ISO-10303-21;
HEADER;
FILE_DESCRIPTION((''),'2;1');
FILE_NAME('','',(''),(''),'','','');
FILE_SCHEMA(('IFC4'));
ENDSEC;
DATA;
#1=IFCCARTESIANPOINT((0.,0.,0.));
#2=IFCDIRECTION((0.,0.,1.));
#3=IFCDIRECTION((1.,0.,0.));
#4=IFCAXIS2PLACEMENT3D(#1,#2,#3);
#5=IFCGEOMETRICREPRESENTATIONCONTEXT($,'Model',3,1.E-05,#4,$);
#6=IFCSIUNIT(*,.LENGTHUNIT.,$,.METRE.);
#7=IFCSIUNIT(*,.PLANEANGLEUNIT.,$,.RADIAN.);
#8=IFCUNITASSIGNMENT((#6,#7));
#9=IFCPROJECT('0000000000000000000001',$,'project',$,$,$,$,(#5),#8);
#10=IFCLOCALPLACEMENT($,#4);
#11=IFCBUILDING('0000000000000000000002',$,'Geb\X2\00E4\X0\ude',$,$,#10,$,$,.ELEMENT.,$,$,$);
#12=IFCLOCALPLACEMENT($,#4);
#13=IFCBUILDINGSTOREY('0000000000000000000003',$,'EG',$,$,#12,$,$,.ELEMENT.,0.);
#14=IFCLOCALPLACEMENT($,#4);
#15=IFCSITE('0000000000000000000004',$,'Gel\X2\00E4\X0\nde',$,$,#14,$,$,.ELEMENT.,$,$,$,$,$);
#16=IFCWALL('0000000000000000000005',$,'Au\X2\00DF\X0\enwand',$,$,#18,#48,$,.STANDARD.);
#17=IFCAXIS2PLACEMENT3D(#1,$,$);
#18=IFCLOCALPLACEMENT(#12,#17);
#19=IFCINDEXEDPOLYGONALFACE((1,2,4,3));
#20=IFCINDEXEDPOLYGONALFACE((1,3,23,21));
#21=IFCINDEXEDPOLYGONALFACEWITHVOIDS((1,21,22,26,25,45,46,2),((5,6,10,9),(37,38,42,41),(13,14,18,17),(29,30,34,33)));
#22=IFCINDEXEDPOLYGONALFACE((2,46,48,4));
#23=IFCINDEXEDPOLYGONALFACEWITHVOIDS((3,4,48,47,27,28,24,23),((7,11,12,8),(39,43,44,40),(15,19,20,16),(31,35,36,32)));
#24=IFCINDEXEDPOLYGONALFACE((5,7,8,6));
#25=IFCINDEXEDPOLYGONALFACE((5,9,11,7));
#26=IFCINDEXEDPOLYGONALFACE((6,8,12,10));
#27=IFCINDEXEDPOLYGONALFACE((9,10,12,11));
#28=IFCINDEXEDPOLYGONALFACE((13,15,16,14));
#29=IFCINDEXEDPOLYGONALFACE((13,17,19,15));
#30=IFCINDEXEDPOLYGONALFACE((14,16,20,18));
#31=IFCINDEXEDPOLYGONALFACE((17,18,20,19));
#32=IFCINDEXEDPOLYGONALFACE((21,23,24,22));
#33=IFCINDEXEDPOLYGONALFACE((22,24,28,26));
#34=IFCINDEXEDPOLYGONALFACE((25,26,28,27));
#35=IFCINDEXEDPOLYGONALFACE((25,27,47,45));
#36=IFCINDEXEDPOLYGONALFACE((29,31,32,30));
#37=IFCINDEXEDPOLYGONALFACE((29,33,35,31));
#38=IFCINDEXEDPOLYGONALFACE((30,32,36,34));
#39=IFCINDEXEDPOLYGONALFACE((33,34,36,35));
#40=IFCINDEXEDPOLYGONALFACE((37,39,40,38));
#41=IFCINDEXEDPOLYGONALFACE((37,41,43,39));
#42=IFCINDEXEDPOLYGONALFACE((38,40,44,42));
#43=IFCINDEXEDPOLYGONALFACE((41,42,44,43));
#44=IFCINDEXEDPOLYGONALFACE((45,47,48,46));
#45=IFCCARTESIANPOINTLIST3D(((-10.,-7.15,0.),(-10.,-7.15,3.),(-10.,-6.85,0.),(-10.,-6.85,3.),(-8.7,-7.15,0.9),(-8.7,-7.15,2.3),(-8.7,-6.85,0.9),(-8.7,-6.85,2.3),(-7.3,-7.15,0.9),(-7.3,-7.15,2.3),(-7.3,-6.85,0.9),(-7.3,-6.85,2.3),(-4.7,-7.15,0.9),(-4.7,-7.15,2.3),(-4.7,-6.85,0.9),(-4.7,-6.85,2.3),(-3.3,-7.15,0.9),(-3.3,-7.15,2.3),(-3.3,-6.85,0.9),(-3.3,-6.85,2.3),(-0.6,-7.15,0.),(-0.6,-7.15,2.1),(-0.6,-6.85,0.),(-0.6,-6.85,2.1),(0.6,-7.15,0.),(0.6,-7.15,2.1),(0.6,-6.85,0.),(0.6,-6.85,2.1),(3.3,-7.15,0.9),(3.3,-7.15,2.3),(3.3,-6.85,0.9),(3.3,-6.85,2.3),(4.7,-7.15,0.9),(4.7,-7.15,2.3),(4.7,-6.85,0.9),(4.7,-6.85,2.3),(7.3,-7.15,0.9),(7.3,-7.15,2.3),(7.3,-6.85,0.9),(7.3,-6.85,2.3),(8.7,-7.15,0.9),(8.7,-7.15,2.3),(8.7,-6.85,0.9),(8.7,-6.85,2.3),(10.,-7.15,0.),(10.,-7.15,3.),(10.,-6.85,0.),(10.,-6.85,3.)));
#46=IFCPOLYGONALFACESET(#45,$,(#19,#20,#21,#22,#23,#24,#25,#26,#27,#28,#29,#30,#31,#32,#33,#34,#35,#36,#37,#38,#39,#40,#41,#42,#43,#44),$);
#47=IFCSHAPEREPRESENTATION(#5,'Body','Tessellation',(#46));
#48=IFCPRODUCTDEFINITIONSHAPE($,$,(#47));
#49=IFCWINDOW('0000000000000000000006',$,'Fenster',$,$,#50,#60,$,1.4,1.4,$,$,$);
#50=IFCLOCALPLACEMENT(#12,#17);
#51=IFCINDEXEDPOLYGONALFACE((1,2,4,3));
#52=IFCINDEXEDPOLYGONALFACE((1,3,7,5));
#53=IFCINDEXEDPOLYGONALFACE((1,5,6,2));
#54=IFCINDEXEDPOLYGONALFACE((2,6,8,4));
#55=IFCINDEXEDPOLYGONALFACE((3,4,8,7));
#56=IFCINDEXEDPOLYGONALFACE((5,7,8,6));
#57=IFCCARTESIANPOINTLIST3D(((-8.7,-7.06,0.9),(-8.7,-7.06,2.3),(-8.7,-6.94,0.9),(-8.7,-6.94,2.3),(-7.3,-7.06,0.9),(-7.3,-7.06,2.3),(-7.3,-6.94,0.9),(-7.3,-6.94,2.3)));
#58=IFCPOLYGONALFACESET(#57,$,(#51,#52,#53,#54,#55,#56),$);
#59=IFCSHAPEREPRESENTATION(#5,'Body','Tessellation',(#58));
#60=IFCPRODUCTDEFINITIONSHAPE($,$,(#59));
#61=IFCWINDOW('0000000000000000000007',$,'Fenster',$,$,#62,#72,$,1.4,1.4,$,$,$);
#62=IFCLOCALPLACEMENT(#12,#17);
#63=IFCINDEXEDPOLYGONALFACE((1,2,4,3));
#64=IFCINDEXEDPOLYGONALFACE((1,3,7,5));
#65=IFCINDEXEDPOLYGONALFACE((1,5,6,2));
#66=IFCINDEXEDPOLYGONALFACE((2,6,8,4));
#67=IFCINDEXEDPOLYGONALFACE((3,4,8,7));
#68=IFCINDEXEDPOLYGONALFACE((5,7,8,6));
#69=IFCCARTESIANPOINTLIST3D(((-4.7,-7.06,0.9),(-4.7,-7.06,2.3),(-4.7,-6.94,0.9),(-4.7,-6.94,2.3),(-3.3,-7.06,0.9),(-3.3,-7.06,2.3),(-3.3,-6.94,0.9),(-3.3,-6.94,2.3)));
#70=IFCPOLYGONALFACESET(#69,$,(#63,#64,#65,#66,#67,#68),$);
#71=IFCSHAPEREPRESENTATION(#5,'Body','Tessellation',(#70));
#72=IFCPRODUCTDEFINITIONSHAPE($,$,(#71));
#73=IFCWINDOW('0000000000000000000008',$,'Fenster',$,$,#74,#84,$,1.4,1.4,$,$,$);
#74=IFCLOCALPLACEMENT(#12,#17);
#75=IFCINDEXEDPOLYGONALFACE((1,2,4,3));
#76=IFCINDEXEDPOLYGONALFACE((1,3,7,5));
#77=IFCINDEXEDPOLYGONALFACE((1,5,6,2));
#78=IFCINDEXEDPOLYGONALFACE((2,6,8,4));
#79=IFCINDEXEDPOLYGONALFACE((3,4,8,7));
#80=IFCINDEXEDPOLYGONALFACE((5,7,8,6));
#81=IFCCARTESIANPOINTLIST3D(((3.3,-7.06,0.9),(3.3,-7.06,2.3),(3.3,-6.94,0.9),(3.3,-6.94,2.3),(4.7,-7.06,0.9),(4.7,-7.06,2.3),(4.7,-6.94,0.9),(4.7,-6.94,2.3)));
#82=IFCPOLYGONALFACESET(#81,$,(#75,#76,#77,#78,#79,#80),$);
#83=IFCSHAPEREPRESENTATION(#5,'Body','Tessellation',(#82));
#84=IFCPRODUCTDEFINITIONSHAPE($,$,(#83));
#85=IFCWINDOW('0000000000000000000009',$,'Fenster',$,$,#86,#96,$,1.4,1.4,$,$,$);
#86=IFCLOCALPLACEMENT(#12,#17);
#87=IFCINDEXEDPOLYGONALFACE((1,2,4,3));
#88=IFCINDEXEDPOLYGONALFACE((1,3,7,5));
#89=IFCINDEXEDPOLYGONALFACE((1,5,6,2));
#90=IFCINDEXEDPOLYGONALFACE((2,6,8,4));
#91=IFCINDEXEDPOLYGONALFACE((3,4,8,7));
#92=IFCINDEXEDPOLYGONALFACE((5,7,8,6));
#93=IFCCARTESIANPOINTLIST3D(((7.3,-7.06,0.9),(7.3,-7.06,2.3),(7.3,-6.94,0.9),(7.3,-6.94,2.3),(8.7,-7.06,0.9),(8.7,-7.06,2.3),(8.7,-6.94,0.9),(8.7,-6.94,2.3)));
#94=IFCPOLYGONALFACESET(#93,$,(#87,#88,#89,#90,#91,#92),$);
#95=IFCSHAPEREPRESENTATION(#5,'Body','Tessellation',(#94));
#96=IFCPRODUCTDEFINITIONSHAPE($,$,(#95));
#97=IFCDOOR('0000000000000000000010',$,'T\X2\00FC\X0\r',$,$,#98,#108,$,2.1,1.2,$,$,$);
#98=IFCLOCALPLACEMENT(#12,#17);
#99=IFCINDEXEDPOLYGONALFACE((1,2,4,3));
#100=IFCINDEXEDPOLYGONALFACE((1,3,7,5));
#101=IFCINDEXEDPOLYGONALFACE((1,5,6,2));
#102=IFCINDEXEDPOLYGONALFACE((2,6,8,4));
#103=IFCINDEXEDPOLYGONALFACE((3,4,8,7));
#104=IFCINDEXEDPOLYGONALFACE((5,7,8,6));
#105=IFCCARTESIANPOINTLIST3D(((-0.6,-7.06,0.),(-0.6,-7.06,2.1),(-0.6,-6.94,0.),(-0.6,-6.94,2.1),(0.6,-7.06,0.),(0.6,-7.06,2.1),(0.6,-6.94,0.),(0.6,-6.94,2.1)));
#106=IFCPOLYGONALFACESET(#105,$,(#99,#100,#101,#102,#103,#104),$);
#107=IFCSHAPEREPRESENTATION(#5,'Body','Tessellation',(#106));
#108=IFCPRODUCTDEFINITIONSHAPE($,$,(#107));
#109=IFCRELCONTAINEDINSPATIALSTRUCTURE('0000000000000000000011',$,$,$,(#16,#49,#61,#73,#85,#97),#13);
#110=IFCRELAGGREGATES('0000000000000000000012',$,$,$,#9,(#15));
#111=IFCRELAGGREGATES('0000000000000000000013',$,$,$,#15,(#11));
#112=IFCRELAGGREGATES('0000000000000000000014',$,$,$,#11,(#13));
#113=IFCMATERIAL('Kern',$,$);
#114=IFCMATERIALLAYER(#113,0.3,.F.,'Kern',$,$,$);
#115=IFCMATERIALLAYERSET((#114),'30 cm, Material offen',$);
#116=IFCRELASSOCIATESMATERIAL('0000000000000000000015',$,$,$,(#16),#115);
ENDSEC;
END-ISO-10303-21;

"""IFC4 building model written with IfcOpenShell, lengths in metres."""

from ifc_helpers import new_model, si_unit, frame, origin_with_axes, origin_2d, place, context, project, spatial, rectangle, extrude, material, layer, layer_set, element, fill, save


model = new_model("IFC4")

# Units and contexts
model_context = context("Model", 3, precision=1e-05, world=origin_with_axes())
ifc_project = project(units=[si_unit("LENGTHUNIT", "METRE"), si_unit("PLANEANGLEUNIT", "RADIAN")], contexts=[model_context])

# Site, building, storey
site_placement = place(None, origin_with_axes())
site = spatial("IfcSite", under=ifc_project, at=site_placement, Name="Gelände", CompositionType="ELEMENT")
building_placement = place(None, origin_with_axes())
building = spatial("IfcBuilding", under=site, at=building_placement, Name="Gebäude", CompositionType="ELEMENT")
storey_placement = place(None, origin_with_axes())
storey = spatial("IfcBuildingStorey", under=building, at=storey_placement, Name="EG", CompositionType="ELEMENT", Elevation=0.0)

# Wall, openings, windows, door
ifc_material = material(Name="Kern")
ifc_layer = layer(ifc_material, 0.3, ventilated=False, Name="Kern")
ifc_layer_set = layer_set([ifc_layer], Name="30 cm, Material offen")
wall_1_placement = place(None, frame((0.0, -7.0, 0.0), z_axis=(0.0, 0.0, 1.0), x_axis=(1.0, 0.0, 0.0)))
wall_1 = element("IfcWall", 1, at=wall_1_placement, inside=storey, material=ifc_layer_set, Name="Außenwand", PredefinedType="STANDARD", context=model_context, shape_type="SweptSolid", body=[
    extrude(rectangle(XDim=20.0, YDim=0.3, at=origin_2d()), origin_with_axes(), (0.0, 0.0, 1.0), 3.0),
])
opening_1_placement = place(wall_1_placement, frame((-8.0, 0.0, 0.9), z_axis=(0.0, 0.0, 1.0), x_axis=(1.0, 0.0, 0.0)))
opening_1 = element("IfcOpeningElement", 2, at=opening_1_placement, cuts=wall_1, PredefinedType="OPENING", context=model_context, shape_type="SweptSolid", body=[
    extrude(rectangle(XDim=1.4, YDim=0.34, at=origin_2d()), origin_with_axes(), (0.0, 0.0, 1.0), 1.4),
])
opening_2_placement = place(wall_1_placement, frame((-4.0, 0.0, 0.9), z_axis=(0.0, 0.0, 1.0), x_axis=(1.0, 0.0, 0.0)))
opening_2 = element("IfcOpeningElement", 3, at=opening_2_placement, cuts=wall_1, PredefinedType="OPENING", context=model_context, shape_type="SweptSolid", body=[
    extrude(rectangle(XDim=1.4, YDim=0.34, at=origin_2d()), origin_with_axes(), (0.0, 0.0, 1.0), 1.4),
])
opening_3_placement = place(wall_1_placement, frame((4.0, 0.0, 0.9), z_axis=(0.0, 0.0, 1.0), x_axis=(1.0, 0.0, 0.0)))
opening_3 = element("IfcOpeningElement", 4, at=opening_3_placement, cuts=wall_1, PredefinedType="OPENING", context=model_context, shape_type="SweptSolid", body=[
    extrude(rectangle(XDim=1.4, YDim=0.34, at=origin_2d()), origin_with_axes(), (0.0, 0.0, 1.0), 1.4),
])
opening_4_placement = place(wall_1_placement, frame((8.0, 0.0, 0.9), z_axis=(0.0, 0.0, 1.0), x_axis=(1.0, 0.0, 0.0)))
opening_4 = element("IfcOpeningElement", 5, at=opening_4_placement, cuts=wall_1, PredefinedType="OPENING", context=model_context, shape_type="SweptSolid", body=[
    extrude(rectangle(XDim=1.4, YDim=0.34, at=origin_2d()), origin_with_axes(), (0.0, 0.0, 1.0), 1.4),
])
opening_5_placement = place(wall_1_placement, origin_with_axes())
opening_5 = element("IfcOpeningElement", 6, at=opening_5_placement, cuts=wall_1, PredefinedType="OPENING", context=model_context, shape_type="SweptSolid", body=[
    extrude(rectangle(XDim=1.2, YDim=0.34, at=origin_2d()), origin_with_axes(), (0.0, 0.0, 1.0), 2.1),
])
window_1_placement = place(opening_1_placement, origin_with_axes())
window_1 = element("IfcWindow", 7, at=window_1_placement, inside=storey, Name="Fenster", OverallHeight=1.4, OverallWidth=1.4, context=model_context, shape_type="SweptSolid", body=[
    extrude(rectangle(XDim=1.4, YDim=0.12, at=origin_2d()), origin_with_axes(), (0.0, 0.0, 1.0), 1.4),
])
fill(opening_1, window_1)
window_2_placement = place(opening_2_placement, origin_with_axes())
window_2 = element("IfcWindow", 8, at=window_2_placement, inside=storey, Name="Fenster", OverallHeight=1.4, OverallWidth=1.4, context=model_context, shape_type="SweptSolid", body=[
    extrude(rectangle(XDim=1.4, YDim=0.12, at=origin_2d()), origin_with_axes(), (0.0, 0.0, 1.0), 1.4),
])
fill(opening_2, window_2)
window_3_placement = place(opening_3_placement, origin_with_axes())
window_3 = element("IfcWindow", 9, at=window_3_placement, inside=storey, Name="Fenster", OverallHeight=1.4, OverallWidth=1.4, context=model_context, shape_type="SweptSolid", body=[
    extrude(rectangle(XDim=1.4, YDim=0.12, at=origin_2d()), origin_with_axes(), (0.0, 0.0, 1.0), 1.4),
])
fill(opening_3, window_3)
window_4_placement = place(opening_4_placement, origin_with_axes())
window_4 = element("IfcWindow", 10, at=window_4_placement, inside=storey, Name="Fenster", OverallHeight=1.4, OverallWidth=1.4, context=model_context, shape_type="SweptSolid", body=[
    extrude(rectangle(XDim=1.4, YDim=0.12, at=origin_2d()), origin_with_axes(), (0.0, 0.0, 1.0), 1.4),
])
fill(opening_4, window_4)
door_placement = place(opening_5_placement, origin_with_axes())
door = element("IfcDoor", 11, at=door_placement, inside=storey, Name="Tür", OverallHeight=2.1, OverallWidth=1.2, context=model_context, shape_type="SweptSolid", body=[
    extrude(rectangle(XDim=1.2, YDim=0.12, at=origin_2d()), origin_with_axes(), (0.0, 0.0, 1.0), 2.1),
])
fill(opening_5, door)

save(model, "model.ifc")
